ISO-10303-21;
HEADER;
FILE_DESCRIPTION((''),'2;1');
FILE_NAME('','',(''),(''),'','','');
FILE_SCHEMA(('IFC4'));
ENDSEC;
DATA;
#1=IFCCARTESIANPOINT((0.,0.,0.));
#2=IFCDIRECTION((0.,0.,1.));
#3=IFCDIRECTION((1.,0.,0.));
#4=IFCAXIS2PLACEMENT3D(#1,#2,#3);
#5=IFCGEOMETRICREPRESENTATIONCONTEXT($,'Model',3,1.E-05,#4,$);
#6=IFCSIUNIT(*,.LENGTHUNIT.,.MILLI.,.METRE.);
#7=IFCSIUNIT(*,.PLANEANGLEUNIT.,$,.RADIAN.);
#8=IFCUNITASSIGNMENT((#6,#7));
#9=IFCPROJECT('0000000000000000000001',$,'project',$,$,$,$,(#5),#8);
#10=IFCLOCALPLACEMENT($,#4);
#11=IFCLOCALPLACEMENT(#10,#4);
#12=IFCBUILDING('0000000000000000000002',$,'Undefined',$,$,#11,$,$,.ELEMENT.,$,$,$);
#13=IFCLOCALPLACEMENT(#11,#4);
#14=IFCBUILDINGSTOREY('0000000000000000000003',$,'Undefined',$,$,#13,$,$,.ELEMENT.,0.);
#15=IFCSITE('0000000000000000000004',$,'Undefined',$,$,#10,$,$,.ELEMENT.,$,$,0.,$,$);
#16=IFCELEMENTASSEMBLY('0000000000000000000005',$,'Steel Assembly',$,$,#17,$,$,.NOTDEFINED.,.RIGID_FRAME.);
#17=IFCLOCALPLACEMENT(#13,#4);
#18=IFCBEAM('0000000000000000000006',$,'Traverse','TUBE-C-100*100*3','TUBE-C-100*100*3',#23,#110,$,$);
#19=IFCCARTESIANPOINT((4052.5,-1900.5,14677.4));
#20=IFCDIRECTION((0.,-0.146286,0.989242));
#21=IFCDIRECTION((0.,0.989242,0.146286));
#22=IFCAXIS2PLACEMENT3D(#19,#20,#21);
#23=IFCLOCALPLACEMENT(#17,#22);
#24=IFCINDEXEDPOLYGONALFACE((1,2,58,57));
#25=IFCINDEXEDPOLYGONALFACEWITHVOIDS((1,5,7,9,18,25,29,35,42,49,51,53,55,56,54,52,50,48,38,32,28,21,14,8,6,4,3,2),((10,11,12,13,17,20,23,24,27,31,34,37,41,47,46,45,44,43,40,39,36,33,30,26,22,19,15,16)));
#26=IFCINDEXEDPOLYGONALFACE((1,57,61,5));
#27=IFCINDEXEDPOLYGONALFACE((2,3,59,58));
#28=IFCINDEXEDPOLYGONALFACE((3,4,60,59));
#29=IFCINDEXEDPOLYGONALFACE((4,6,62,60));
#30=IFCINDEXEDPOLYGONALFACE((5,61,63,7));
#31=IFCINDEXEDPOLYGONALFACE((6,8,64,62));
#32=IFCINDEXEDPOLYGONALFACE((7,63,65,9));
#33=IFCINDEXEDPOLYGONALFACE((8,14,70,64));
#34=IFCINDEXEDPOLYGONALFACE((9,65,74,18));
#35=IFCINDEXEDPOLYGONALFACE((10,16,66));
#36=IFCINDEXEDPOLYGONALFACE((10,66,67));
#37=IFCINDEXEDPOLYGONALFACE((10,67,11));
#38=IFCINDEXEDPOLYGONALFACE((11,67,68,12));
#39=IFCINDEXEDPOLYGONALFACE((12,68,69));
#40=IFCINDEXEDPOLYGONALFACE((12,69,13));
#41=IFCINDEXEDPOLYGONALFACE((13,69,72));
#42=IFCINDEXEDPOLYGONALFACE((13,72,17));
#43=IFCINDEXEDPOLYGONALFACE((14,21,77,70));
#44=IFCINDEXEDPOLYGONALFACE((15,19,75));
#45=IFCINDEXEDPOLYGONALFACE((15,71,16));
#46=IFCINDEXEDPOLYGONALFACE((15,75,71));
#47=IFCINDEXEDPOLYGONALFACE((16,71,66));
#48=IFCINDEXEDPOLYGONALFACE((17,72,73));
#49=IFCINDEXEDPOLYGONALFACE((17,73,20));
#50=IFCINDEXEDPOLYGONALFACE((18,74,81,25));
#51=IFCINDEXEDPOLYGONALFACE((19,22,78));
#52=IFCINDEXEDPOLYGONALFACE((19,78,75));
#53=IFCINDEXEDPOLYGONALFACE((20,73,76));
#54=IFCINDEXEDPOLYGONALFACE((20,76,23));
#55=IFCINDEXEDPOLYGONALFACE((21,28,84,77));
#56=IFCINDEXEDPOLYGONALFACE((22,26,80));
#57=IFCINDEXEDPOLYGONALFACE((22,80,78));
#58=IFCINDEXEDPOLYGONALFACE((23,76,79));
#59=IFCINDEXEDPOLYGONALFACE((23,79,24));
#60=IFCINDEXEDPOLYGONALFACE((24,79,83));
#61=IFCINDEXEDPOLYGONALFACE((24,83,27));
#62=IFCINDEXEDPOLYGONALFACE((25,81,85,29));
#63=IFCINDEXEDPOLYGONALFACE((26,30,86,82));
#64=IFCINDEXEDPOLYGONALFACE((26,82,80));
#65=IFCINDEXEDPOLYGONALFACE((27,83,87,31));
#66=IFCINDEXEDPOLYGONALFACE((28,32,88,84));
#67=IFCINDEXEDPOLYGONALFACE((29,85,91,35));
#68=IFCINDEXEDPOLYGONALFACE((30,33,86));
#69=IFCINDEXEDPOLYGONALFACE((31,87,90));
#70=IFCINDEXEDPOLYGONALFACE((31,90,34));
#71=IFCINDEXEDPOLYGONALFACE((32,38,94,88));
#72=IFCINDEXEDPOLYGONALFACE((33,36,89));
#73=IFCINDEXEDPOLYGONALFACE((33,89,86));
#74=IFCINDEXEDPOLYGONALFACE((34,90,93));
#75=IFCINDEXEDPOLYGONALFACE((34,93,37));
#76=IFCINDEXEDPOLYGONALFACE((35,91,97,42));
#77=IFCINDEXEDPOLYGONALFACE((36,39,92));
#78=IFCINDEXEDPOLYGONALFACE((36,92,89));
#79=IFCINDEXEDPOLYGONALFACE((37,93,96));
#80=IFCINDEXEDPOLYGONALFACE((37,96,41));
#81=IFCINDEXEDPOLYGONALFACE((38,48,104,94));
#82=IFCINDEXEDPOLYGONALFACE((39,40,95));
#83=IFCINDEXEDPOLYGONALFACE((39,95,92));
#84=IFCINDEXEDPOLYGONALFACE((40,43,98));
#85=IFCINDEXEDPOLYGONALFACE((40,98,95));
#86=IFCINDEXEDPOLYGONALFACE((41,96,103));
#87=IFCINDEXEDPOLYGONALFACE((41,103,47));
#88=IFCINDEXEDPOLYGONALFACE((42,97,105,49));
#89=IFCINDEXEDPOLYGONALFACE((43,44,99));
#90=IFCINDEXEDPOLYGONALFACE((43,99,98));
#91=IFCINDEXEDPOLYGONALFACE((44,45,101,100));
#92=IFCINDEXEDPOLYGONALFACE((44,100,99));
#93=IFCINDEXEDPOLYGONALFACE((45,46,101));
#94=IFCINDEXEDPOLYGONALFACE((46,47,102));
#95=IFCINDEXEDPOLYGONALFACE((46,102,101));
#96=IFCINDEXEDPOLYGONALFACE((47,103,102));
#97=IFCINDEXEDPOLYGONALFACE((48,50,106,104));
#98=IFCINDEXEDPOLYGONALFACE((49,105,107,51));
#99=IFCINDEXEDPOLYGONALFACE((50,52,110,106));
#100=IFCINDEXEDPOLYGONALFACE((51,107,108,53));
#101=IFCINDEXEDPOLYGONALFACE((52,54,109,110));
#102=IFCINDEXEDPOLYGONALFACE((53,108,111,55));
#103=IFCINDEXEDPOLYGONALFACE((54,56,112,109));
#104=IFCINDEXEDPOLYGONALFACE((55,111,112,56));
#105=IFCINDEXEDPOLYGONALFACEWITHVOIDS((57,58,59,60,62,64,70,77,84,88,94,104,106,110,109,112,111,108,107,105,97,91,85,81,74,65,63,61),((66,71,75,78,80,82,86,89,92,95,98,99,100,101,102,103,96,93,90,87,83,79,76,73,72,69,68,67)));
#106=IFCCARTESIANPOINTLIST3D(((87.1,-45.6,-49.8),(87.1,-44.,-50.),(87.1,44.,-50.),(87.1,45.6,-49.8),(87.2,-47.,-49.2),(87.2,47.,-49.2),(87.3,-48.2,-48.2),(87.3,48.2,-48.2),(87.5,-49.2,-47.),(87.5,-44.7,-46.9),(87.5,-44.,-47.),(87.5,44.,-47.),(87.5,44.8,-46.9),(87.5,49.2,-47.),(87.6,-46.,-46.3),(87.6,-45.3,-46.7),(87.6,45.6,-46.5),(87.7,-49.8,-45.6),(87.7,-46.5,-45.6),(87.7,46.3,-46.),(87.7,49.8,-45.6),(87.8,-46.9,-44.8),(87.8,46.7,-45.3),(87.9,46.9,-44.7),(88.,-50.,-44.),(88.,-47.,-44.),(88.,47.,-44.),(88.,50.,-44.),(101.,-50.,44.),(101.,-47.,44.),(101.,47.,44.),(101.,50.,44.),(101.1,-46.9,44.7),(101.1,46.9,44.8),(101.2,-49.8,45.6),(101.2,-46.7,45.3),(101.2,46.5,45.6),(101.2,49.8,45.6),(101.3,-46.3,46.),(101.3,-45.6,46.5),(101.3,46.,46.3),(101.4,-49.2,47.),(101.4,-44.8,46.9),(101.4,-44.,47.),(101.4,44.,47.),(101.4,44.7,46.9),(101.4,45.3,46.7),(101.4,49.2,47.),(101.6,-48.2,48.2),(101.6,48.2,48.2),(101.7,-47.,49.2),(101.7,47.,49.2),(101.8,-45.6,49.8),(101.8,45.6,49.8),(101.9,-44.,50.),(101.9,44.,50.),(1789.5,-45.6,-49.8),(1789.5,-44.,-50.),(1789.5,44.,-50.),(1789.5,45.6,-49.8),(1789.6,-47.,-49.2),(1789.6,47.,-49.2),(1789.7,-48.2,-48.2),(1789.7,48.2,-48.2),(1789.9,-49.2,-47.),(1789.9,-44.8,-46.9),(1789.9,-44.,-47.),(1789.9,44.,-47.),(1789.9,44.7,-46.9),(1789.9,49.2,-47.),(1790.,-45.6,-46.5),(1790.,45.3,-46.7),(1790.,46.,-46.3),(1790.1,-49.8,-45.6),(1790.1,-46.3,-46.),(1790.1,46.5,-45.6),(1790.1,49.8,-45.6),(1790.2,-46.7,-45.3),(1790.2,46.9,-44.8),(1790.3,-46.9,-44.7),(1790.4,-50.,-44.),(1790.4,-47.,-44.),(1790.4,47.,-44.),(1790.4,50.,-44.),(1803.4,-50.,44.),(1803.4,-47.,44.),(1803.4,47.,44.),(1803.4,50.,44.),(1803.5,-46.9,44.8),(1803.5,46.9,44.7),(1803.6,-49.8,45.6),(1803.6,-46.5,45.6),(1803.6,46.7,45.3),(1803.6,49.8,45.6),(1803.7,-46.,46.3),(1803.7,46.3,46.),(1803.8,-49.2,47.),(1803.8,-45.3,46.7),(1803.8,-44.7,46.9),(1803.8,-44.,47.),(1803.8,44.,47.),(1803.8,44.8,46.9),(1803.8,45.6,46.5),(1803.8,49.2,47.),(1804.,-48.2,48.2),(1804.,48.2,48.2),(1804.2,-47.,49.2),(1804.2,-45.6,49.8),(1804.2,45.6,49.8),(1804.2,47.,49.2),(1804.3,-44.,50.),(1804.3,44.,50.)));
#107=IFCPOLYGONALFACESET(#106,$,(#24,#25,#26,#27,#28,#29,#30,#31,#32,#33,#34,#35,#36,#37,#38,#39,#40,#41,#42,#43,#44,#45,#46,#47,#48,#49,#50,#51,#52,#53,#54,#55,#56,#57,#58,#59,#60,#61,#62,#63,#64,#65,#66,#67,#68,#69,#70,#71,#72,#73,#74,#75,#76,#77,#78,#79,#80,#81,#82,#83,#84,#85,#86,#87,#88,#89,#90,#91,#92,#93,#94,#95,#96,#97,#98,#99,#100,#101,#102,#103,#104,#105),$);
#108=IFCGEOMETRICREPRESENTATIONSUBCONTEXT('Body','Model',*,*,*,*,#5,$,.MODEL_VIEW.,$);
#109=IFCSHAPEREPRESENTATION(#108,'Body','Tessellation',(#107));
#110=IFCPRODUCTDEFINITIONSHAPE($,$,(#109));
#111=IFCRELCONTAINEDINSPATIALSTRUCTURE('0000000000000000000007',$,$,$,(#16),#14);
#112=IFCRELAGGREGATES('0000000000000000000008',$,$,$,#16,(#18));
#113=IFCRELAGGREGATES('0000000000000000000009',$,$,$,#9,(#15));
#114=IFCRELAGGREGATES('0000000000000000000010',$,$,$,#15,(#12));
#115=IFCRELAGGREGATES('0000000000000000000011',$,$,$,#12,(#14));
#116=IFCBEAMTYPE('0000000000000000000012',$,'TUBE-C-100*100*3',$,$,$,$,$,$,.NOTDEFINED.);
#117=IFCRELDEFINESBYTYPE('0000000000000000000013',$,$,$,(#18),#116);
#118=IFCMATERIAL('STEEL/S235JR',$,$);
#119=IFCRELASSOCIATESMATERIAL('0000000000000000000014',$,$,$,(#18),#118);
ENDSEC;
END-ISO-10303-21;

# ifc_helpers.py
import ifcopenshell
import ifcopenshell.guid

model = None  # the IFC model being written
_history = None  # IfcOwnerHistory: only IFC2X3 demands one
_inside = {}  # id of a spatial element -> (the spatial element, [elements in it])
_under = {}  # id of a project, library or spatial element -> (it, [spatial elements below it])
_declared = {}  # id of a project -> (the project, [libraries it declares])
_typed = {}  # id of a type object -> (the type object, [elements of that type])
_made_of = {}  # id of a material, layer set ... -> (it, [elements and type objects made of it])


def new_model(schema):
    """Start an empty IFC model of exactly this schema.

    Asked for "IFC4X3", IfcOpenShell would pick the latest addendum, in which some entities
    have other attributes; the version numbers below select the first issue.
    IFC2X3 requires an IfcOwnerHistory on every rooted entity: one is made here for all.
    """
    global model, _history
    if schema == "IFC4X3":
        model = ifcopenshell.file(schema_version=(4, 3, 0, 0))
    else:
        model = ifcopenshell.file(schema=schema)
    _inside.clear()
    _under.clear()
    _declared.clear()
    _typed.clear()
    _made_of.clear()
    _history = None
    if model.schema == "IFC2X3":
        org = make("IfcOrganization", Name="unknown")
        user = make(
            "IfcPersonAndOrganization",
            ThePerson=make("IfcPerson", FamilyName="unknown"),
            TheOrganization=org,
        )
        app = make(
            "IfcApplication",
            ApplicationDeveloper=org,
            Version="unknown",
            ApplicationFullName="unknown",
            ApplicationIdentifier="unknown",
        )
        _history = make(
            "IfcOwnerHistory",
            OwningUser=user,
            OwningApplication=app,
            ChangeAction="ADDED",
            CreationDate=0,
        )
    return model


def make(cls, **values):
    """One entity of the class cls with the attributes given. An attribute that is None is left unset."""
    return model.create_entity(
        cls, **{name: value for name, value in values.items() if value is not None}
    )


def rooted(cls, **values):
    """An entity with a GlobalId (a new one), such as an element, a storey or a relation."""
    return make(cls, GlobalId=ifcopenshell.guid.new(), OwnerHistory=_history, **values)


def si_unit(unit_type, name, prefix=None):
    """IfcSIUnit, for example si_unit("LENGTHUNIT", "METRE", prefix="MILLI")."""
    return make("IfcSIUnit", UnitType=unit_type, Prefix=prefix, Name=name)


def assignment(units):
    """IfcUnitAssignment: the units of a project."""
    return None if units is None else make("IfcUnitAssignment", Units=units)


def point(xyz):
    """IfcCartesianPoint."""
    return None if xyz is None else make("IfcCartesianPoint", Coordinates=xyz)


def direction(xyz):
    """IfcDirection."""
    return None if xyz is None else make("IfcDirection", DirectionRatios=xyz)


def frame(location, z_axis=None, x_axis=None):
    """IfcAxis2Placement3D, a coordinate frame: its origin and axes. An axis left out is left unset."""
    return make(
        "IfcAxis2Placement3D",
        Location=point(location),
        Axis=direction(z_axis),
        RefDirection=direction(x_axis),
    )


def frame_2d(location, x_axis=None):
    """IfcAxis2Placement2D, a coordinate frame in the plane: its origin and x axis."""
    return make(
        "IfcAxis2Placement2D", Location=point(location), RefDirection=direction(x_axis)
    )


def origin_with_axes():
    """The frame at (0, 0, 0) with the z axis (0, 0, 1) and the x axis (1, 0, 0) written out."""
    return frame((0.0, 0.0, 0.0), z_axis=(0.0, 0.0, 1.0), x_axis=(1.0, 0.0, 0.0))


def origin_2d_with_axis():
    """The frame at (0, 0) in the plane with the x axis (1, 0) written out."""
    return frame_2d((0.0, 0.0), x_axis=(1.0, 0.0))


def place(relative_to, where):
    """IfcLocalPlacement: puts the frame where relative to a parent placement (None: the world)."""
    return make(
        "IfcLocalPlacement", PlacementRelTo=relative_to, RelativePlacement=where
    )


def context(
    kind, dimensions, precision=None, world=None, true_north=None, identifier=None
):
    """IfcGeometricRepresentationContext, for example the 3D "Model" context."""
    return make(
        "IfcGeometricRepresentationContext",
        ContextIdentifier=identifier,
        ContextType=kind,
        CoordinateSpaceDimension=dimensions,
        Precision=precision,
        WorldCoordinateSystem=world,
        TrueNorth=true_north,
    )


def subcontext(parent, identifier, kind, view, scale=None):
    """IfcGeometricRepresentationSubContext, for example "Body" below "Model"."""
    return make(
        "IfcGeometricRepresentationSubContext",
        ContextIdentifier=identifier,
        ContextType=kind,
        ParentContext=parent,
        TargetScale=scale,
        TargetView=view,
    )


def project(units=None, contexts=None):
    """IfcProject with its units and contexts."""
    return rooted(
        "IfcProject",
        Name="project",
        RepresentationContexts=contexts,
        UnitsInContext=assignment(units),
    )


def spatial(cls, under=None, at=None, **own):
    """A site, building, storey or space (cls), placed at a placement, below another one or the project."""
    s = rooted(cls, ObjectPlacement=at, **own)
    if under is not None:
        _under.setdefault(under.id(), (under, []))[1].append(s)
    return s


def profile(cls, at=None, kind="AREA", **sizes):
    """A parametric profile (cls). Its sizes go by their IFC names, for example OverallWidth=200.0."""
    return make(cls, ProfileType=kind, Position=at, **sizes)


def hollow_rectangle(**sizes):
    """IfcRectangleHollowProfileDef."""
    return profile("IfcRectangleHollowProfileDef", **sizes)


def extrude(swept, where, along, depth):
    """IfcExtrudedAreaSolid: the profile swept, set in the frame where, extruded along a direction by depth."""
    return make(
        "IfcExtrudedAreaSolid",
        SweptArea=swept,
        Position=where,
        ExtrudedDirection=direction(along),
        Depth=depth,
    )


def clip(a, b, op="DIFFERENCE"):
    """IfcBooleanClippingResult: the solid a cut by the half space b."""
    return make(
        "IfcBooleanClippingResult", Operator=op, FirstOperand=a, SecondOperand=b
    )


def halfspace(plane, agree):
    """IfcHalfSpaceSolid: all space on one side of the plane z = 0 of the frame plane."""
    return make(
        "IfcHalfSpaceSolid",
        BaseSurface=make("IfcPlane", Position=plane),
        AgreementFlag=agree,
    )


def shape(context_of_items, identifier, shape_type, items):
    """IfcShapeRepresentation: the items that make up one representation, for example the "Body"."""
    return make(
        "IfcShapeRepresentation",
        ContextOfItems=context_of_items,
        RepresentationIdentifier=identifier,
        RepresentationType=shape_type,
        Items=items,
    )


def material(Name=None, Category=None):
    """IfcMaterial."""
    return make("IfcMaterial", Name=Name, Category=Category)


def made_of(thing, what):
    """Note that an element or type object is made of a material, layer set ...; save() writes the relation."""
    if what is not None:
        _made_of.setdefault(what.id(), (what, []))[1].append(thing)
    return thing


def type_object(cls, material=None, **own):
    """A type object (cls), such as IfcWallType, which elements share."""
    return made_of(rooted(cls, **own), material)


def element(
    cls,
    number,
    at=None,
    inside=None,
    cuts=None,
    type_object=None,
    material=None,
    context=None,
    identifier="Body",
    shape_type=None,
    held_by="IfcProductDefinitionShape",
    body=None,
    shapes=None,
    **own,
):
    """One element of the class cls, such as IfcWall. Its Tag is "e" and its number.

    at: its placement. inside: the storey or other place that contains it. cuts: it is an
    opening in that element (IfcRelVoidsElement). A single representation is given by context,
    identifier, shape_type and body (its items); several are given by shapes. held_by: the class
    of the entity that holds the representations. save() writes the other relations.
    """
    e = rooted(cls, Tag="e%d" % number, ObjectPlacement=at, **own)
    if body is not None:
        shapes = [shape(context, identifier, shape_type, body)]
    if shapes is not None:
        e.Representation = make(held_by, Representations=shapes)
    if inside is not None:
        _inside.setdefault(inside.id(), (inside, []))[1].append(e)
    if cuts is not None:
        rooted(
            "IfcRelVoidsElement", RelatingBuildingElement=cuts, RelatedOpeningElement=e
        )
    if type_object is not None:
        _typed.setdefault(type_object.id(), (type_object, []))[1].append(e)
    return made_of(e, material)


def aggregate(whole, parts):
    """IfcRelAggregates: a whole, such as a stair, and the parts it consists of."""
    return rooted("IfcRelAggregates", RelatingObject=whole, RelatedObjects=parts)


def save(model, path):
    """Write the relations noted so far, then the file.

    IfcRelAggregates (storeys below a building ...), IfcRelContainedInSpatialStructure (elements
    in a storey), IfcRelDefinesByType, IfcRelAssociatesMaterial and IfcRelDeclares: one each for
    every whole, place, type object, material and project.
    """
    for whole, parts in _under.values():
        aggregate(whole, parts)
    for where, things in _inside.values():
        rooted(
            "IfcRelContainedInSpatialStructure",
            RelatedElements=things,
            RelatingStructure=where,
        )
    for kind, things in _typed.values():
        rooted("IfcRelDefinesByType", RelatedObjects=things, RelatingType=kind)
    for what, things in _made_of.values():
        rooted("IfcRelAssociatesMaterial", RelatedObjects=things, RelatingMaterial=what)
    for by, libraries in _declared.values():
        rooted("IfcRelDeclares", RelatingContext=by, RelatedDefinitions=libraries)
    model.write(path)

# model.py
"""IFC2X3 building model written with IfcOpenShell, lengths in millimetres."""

from ifc_helpers import new_model, si_unit, frame, origin_with_axes, origin_2d_with_axis, place, context, subcontext, project, spatial, hollow_rectangle, extrude, clip, halfspace, material, type_object, element, aggregate, save


model = new_model("IFC2X3")

# Units and contexts
model_context = context("Model", 3, precision=1e-05, world=origin_with_axes())
body_context = subcontext(model_context, "Body", "Model", "MODEL_VIEW")
ifc_project = project(units=[si_unit("LENGTHUNIT", "METRE", prefix="MILLI"), si_unit("PLANEANGLEUNIT", "RADIAN")], contexts=[model_context])

# Site, building, storey
site_placement = place(None, origin_with_axes())
site = spatial("IfcSite", under=ifc_project, at=site_placement, Name="Undefined", CompositionType="ELEMENT", RefElevation=0.0)
building_placement = place(site_placement, origin_with_axes())
building = spatial("IfcBuilding", under=site, at=building_placement, Name="Undefined", CompositionType="ELEMENT")
storey_placement = place(building_placement, origin_with_axes())
storey = spatial("IfcBuildingStorey", under=building, at=storey_placement, Name="Undefined", CompositionType="ELEMENT", Elevation=0.0)

# Element assembly, beam
ifc_material_1 = material(Name="STEEL/S235JR")
assembly_1_placement = place(storey_placement, origin_with_axes())
assembly_1 = element("IfcElementAssembly", 1, at=assembly_1_placement, inside=storey, Name="Steel Assembly", AssemblyPlace="NOTDEFINED", PredefinedType="RIGID_FRAME")
beam_type_1 = type_object("IfcBeamType", Name="TUBE-C-100*100*3", PredefinedType="NOTDEFINED")
beam_1_placement = place(assembly_1_placement, frame((4052.5, -1900.5, 14677.4), z_axis=(0.0, -0.146286, 0.989242), x_axis=(0.0, 0.989242, 0.146286)))
beam_1 = element("IfcBeam", 2, at=beam_1_placement, type_object=beam_type_1, material=ifc_material_1, Name="Traverse", Description="TUBE-C-100*100*3", ObjectType="TUBE-C-100*100*3", context=body_context, shape_type="Clipping", body=[
    clip(clip(extrude(hollow_rectangle(XDim=100.0, YDim=100.0, WallThickness=3.0, InnerFilletRadius=3.0, OuterFilletRadius=6.0, at=origin_2d_with_axis()), frame((1811.8, 0.0, 0.0), z_axis=(-1.0, 0.0, 0.0), x_axis=(0.0, -1.0, 0.0)), (0.0, 0.0, 1.0), 1732.3), halfspace(frame((1789.5, 0.0, -50.0), z_axis=(-0.989242, 0.0, 0.146286), x_axis=(0.0, 1.0, 0.0)), True)), halfspace(frame((91.1, 0.0, -22.5), z_axis=(0.989242, 0.0, -0.146286), x_axis=(0.0, -1.0, 0.0)), True)),
])

aggregate(assembly_1, [beam_1])

save(model, "model.ifc")
